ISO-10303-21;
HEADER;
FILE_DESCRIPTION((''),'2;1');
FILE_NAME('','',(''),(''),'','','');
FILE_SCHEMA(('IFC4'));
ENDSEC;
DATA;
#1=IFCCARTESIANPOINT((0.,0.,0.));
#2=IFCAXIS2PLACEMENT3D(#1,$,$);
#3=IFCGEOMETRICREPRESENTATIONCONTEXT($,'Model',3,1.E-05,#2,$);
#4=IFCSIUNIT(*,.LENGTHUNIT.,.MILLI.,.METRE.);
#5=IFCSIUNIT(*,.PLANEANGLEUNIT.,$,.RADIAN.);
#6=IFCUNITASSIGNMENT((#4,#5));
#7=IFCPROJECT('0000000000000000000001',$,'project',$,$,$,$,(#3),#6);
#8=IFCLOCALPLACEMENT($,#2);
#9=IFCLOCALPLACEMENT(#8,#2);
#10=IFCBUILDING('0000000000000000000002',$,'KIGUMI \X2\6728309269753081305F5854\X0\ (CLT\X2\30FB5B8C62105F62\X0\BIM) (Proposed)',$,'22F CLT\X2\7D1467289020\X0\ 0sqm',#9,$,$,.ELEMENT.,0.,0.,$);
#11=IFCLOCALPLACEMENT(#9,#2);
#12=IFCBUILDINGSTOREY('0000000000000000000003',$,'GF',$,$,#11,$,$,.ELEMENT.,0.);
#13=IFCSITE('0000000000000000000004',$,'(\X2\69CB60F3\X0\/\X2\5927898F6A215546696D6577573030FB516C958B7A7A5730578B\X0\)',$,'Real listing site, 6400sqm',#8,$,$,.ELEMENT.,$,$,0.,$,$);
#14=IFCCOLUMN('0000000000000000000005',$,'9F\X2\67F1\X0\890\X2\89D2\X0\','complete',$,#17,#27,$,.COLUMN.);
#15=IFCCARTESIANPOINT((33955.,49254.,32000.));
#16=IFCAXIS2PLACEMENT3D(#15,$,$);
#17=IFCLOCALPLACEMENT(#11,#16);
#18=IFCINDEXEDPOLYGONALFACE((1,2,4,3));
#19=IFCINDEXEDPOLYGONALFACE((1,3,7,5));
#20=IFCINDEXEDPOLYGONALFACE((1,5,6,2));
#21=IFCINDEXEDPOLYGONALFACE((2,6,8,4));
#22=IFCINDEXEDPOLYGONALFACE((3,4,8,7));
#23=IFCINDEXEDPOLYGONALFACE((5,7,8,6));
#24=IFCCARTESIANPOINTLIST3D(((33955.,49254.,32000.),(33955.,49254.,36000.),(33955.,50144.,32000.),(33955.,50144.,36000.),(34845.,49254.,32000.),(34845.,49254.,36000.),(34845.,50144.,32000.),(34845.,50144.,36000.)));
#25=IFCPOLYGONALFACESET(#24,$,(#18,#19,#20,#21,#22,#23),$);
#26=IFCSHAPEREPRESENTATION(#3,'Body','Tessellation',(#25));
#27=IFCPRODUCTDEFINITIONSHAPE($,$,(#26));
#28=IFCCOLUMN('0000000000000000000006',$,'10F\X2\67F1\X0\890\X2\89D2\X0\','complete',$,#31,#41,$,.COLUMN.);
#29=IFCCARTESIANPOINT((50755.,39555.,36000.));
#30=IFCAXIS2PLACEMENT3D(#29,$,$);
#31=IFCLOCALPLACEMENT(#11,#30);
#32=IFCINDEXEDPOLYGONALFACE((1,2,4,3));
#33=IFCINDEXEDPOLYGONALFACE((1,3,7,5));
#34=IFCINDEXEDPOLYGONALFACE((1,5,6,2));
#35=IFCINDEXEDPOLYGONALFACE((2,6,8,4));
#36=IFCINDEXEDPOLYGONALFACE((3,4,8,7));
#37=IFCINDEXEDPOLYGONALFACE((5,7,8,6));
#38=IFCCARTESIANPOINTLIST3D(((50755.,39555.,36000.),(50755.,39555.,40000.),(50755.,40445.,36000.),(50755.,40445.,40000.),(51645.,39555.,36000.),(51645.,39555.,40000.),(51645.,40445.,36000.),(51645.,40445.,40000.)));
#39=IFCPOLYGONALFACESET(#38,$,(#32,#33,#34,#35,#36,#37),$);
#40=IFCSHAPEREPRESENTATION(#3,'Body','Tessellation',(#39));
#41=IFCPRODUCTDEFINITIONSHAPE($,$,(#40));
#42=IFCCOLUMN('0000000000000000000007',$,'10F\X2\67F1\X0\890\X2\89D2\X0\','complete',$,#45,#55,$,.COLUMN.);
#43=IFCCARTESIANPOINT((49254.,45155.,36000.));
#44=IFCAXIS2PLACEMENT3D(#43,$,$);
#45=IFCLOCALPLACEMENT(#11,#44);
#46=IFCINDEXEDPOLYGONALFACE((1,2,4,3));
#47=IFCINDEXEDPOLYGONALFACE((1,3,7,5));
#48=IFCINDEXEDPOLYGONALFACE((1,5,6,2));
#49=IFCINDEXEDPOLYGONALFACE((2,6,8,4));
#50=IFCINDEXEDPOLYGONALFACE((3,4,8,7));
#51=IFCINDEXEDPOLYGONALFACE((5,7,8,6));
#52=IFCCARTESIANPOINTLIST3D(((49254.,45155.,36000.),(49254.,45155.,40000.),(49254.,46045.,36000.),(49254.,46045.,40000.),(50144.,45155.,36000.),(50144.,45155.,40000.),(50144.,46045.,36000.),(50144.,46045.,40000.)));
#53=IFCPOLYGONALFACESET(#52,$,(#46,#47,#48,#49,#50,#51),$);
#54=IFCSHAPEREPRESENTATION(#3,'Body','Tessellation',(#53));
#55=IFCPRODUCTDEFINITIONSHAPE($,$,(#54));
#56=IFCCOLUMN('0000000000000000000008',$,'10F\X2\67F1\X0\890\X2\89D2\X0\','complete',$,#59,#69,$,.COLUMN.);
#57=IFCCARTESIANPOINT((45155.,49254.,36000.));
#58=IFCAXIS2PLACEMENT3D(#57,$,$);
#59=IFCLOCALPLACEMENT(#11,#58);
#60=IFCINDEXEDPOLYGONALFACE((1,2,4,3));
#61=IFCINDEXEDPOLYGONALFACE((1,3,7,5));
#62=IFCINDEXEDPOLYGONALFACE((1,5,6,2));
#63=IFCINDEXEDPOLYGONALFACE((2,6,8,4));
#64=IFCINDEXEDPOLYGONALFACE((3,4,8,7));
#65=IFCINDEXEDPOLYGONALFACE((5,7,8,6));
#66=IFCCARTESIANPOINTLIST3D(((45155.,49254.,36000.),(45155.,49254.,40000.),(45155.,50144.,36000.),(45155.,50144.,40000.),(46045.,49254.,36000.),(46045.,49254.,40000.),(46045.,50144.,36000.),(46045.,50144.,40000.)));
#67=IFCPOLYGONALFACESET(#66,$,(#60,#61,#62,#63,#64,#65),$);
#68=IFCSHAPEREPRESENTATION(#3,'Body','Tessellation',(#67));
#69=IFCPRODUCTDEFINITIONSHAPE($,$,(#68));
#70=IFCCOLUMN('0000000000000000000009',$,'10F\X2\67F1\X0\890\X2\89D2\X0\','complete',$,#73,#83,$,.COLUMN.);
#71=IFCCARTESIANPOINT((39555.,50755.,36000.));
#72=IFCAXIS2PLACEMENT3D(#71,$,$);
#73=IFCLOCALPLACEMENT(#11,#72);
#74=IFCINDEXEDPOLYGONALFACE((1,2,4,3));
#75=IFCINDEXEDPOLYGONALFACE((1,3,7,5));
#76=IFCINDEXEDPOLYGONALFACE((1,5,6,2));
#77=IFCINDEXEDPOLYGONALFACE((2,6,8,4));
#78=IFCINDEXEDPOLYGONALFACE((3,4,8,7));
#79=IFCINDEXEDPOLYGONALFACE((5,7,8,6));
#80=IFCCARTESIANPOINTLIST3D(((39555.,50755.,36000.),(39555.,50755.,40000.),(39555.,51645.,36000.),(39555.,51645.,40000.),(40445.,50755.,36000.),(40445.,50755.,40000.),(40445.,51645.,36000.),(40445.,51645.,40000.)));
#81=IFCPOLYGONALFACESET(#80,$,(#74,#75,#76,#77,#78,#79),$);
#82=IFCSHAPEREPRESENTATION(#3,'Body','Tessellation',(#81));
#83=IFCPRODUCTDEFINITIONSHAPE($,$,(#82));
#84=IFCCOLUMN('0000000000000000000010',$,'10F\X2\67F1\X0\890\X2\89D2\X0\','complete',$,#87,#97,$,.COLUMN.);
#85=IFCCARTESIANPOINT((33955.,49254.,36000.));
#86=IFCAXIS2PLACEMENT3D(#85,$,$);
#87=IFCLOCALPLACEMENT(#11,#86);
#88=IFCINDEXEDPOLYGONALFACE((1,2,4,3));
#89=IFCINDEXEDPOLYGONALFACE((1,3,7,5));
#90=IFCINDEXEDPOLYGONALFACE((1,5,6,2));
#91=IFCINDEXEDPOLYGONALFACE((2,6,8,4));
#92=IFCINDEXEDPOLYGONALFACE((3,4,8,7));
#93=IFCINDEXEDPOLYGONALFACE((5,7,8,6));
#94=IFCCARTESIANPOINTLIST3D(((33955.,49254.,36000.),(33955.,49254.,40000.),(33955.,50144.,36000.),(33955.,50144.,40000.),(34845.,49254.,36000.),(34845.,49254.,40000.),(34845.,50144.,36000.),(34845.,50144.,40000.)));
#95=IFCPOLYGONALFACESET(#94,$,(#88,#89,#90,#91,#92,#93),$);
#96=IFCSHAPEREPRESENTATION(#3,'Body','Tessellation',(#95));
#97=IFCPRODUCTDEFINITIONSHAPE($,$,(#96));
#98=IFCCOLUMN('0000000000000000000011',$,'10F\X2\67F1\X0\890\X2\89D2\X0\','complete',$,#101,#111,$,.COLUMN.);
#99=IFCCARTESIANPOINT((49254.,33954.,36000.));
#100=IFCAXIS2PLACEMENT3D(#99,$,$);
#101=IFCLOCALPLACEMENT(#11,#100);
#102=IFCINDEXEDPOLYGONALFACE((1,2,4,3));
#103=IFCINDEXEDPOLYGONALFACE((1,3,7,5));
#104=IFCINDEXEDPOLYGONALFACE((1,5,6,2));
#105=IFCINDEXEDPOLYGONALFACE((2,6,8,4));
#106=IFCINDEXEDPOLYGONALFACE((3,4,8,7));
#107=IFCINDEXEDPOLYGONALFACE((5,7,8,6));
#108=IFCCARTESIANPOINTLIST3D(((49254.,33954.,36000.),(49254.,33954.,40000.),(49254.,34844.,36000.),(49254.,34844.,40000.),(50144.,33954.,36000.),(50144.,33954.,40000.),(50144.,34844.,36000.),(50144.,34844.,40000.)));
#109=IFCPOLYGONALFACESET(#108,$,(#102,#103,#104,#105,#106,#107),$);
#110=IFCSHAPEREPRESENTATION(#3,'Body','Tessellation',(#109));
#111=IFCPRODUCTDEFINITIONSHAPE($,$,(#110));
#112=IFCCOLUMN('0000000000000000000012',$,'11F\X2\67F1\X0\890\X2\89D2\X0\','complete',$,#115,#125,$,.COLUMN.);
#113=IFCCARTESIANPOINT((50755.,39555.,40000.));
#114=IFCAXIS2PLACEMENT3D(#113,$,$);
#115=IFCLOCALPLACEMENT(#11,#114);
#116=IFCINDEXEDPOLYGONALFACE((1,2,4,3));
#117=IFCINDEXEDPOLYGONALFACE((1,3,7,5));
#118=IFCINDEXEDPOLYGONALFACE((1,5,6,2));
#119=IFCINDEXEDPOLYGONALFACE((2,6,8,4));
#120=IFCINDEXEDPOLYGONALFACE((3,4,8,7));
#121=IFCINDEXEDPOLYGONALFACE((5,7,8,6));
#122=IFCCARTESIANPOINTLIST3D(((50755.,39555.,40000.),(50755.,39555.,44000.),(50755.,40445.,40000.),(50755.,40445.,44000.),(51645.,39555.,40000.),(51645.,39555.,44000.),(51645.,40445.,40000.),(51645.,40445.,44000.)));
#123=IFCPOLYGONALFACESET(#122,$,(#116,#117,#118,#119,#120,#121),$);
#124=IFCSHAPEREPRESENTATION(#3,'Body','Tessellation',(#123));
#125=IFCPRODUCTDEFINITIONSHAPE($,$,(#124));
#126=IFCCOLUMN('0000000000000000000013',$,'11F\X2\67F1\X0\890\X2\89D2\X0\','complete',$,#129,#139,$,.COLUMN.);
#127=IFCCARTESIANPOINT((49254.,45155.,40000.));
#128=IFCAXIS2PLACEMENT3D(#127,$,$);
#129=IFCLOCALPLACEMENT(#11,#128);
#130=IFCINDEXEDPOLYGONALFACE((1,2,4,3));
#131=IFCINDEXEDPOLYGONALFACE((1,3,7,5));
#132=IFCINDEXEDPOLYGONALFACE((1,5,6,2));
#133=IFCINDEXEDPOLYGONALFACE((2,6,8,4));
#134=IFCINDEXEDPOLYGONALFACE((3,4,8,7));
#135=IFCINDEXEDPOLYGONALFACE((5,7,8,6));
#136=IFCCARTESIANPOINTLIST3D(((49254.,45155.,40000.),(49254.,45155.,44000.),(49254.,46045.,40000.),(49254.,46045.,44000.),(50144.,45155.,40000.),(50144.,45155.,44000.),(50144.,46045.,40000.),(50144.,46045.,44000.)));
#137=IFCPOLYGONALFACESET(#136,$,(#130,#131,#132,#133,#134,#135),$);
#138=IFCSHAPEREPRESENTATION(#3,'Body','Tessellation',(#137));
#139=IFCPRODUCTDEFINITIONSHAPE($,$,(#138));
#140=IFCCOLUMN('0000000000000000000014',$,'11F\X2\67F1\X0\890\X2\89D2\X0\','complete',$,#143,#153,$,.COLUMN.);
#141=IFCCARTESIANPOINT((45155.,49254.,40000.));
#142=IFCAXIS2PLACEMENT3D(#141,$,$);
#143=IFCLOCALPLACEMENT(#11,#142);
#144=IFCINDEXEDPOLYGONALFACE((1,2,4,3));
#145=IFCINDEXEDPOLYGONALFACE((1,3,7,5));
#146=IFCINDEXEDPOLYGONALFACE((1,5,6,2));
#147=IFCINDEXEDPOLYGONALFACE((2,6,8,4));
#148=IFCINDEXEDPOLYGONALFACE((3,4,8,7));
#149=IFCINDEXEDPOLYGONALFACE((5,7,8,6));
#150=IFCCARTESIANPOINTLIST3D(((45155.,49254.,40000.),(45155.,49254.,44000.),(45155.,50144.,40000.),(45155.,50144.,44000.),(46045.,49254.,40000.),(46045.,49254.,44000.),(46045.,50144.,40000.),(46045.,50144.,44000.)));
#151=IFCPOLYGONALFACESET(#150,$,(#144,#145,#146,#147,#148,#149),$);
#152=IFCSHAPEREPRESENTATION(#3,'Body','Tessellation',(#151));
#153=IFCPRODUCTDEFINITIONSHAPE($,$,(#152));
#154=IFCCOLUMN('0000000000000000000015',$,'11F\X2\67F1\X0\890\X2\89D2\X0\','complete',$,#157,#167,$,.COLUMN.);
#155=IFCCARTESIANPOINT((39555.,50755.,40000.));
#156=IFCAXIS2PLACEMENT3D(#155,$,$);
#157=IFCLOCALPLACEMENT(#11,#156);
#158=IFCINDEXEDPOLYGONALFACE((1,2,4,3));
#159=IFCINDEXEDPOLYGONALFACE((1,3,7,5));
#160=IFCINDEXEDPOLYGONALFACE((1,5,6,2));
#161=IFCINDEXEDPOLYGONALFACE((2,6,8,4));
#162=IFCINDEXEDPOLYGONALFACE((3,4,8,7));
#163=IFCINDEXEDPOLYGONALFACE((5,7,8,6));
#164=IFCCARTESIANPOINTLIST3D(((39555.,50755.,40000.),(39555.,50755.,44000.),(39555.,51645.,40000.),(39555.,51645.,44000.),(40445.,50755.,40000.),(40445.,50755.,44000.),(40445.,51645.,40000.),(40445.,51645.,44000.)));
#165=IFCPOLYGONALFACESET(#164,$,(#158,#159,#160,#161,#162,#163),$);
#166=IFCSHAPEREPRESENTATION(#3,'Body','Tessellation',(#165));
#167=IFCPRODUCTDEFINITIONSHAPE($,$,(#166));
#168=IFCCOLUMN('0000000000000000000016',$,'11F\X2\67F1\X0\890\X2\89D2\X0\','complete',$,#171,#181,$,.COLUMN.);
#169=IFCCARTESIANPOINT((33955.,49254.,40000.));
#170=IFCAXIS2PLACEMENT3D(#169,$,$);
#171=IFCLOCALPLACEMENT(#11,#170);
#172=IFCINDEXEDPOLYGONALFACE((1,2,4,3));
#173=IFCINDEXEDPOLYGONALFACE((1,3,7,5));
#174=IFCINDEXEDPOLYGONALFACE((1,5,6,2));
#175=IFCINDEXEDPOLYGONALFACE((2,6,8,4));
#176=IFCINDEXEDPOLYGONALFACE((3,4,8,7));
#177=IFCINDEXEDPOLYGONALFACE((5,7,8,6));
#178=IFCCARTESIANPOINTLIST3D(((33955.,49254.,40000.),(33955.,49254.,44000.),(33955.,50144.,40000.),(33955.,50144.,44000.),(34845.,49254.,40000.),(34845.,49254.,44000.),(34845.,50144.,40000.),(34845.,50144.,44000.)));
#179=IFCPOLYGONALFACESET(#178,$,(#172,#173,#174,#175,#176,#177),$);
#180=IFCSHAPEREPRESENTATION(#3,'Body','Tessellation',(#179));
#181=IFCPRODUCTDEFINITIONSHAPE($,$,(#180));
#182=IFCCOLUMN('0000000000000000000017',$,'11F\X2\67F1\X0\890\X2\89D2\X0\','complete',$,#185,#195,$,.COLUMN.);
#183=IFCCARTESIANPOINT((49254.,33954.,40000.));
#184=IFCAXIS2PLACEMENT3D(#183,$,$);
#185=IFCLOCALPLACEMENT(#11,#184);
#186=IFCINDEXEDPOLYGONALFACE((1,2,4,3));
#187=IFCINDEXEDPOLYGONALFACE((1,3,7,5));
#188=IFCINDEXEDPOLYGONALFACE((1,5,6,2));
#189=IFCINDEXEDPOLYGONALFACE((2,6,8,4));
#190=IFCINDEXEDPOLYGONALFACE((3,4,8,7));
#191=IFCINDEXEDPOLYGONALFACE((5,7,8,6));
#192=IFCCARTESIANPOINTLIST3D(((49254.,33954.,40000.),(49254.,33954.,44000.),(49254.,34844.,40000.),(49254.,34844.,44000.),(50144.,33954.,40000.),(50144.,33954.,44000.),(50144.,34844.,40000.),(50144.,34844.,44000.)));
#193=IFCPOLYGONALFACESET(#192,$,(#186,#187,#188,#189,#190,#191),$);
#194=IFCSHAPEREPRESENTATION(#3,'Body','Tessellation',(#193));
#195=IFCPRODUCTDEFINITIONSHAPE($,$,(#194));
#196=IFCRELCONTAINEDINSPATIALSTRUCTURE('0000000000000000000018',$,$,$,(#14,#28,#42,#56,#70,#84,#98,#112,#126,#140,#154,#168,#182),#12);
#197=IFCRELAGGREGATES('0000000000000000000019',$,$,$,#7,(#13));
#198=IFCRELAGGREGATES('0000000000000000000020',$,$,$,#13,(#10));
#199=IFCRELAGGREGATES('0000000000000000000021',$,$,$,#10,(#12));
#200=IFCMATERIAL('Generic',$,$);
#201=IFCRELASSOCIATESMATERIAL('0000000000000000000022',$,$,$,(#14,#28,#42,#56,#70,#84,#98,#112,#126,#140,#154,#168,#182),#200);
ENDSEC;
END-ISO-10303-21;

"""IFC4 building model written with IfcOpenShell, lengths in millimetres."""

from ifc_helpers import new_model, si_unit, frame, frame_2d, origin, place, context, project, spatial, rectangle, extrude, material, element, save


model = new_model("IFC4")

# Units and contexts
model_context = context("Model", 3, precision=1e-05, world=origin())
ifc_project = project(units=[si_unit("LENGTHUNIT", "METRE", prefix="MILLI"), si_unit("PLANEANGLEUNIT", "RADIAN")], contexts=[model_context])

# Site, building, storey
site_placement = place(None, origin())
site = spatial("IfcSite", under=ifc_project, at=site_placement, Name="(構想/大規模商業敷地・公開空地型)", ObjectType="Real listing site, 6400sqm", CompositionType="ELEMENT", RefElevation=0.0)
building_placement = place(site_placement, origin())
building = spatial("IfcBuilding", under=site, at=building_placement, Name="KIGUMI 木を極めた塔 (CLT・完成形BIM) (Proposed)", ObjectType="22F CLT純木造 0sqm", CompositionType="ELEMENT", ElevationOfRefHeight=0.0, ElevationOfTerrain=0.0)
storey_placement = place(building_placement, origin())
storey = spatial("IfcBuildingStorey", under=building, at=storey_placement, Name="GF", CompositionType="ELEMENT", Elevation=0.0)

# Columns
ifc_material = material(Name="Generic")
column_1_placement = place(storey_placement, frame((33955.0, 49254.0, 32000.0)))
element("IfcColumn", 1, at=column_1_placement, inside=storey, material=ifc_material, Name="9F柱890角", Description="complete", PredefinedType="COLUMN", context=model_context, shape_type="SweptSolid", body=[
    extrude(rectangle(XDim=890.0, YDim=890.0, at=frame_2d((445.0, 445.0))), frame((33955.0, 49254.0, 32000.0)), (0.0, 0.0, 1.0), 4000.0),
])
column_2_placement = place(storey_placement, frame((50755.0, 39555.0, 36000.0)))
element("IfcColumn", 2, at=column_2_placement, inside=storey, material=ifc_material, Name="10F柱890角", Description="complete", PredefinedType="COLUMN", context=model_context, shape_type="SweptSolid", body=[
    extrude(rectangle(XDim=890.0, YDim=890.0, at=frame_2d((445.0, 445.0))), frame((50755.0, 39555.0, 36000.0)), (0.0, 0.0, 1.0), 4000.0),
])
column_3_placement = place(storey_placement, frame((49254.0, 45155.0, 36000.0)))
element("IfcColumn", 3, at=column_3_placement, inside=storey, material=ifc_material, Name="10F柱890角", Description="complete", PredefinedType="COLUMN", context=model_context, shape_type="SweptSolid", body=[
    extrude(rectangle(XDim=890.0, YDim=890.0, at=frame_2d((445.0, 445.0))), frame((49254.0, 45155.0, 36000.0)), (0.0, 0.0, 1.0), 4000.0),
])
column_4_placement = place(storey_placement, frame((45155.0, 49254.0, 36000.0)))
element("IfcColumn", 4, at=column_4_placement, inside=storey, material=ifc_material, Name="10F柱890角", Description="complete", PredefinedType="COLUMN", context=model_context, shape_type="SweptSolid", body=[
    extrude(rectangle(XDim=890.0, YDim=890.0, at=frame_2d((445.0, 445.0))), frame((45155.0, 49254.0, 36000.0)), (0.0, 0.0, 1.0), 4000.0),
])
column_5_placement = place(storey_placement, frame((39555.0, 50755.0, 36000.0)))
element("IfcColumn", 5, at=column_5_placement, inside=storey, material=ifc_material, Name="10F柱890角", Description="complete", PredefinedType="COLUMN", context=model_context, shape_type="SweptSolid", body=[
    extrude(rectangle(XDim=890.0, YDim=890.0, at=frame_2d((445.0, 445.0))), frame((39555.0, 50755.0, 36000.0)), (0.0, 0.0, 1.0), 4000.0),
])
column_6_placement = place(storey_placement, frame((33955.0, 49254.0, 36000.0)))
element("IfcColumn", 6, at=column_6_placement, inside=storey, material=ifc_material, Name="10F柱890角", Description="complete", PredefinedType="COLUMN", context=model_context, shape_type="SweptSolid", body=[
    extrude(rectangle(XDim=890.0, YDim=890.0, at=frame_2d((445.0, 445.0))), frame((33955.0, 49254.0, 36000.0)), (0.0, 0.0, 1.0), 4000.0),
])
column_7_placement = place(storey_placement, frame((49254.0, 33954.0, 36000.0)))
element("IfcColumn", 7, at=column_7_placement, inside=storey, material=ifc_material, Name="10F柱890角", Description="complete", PredefinedType="COLUMN", context=model_context, shape_type="SweptSolid", body=[
    extrude(rectangle(XDim=890.0, YDim=890.0, at=frame_2d((445.0, 445.0))), frame((49254.0, 33954.0, 36000.0)), (0.0, 0.0, 1.0), 4000.0),
])
column_8_placement = place(storey_placement, frame((50755.0, 39555.0, 40000.0)))
element("IfcColumn", 8, at=column_8_placement, inside=storey, material=ifc_material, Name="11F柱890角", Description="complete", PredefinedType="COLUMN", context=model_context, shape_type="SweptSolid", body=[
    extrude(rectangle(XDim=890.0, YDim=890.0, at=frame_2d((445.0, 445.0))), frame((50755.0, 39555.0, 40000.0)), (0.0, 0.0, 1.0), 4000.0),
])
column_9_placement = place(storey_placement, frame((49254.0, 45155.0, 40000.0)))
element("IfcColumn", 9, at=column_9_placement, inside=storey, material=ifc_material, Name="11F柱890角", Description="complete", PredefinedType="COLUMN", context=model_context, shape_type="SweptSolid", body=[
    extrude(rectangle(XDim=890.0, YDim=890.0, at=frame_2d((445.0, 445.0))), frame((49254.0, 45155.0, 40000.0)), (0.0, 0.0, 1.0), 4000.0),
])
column_10_placement = place(storey_placement, frame((45155.0, 49254.0, 40000.0)))
element("IfcColumn", 10, at=column_10_placement, inside=storey, material=ifc_material, Name="11F柱890角", Description="complete", PredefinedType="COLUMN", context=model_context, shape_type="SweptSolid", body=[
    extrude(rectangle(XDim=890.0, YDim=890.0, at=frame_2d((445.0, 445.0))), frame((45155.0, 49254.0, 40000.0)), (0.0, 0.0, 1.0), 4000.0),
])
column_11_placement = place(storey_placement, frame((39555.0, 50755.0, 40000.0)))
element("IfcColumn", 11, at=column_11_placement, inside=storey, material=ifc_material, Name="11F柱890角", Description="complete", PredefinedType="COLUMN", context=model_context, shape_type="SweptSolid", body=[
    extrude(rectangle(XDim=890.0, YDim=890.0, at=frame_2d((445.0, 445.0))), frame((39555.0, 50755.0, 40000.0)), (0.0, 0.0, 1.0), 4000.0),
])
column_12_placement = place(storey_placement, frame((33955.0, 49254.0, 40000.0)))
element("IfcColumn", 12, at=column_12_placement, inside=storey, material=ifc_material, Name="11F柱890角", Description="complete", PredefinedType="COLUMN", context=model_context, shape_type="SweptSolid", body=[
    extrude(rectangle(XDim=890.0, YDim=890.0, at=frame_2d((445.0, 445.0))), frame((33955.0, 49254.0, 40000.0)), (0.0, 0.0, 1.0), 4000.0),
])
column_13_placement = place(storey_placement, frame((49254.0, 33954.0, 40000.0)))
element("IfcColumn", 13, at=column_13_placement, inside=storey, material=ifc_material, Name="11F柱890角", Description="complete", PredefinedType="COLUMN", context=model_context, shape_type="SweptSolid", body=[
    extrude(rectangle(XDim=890.0, YDim=890.0, at=frame_2d((445.0, 445.0))), frame((49254.0, 33954.0, 40000.0)), (0.0, 0.0, 1.0), 4000.0),
])

save(model, "model.ifc")
